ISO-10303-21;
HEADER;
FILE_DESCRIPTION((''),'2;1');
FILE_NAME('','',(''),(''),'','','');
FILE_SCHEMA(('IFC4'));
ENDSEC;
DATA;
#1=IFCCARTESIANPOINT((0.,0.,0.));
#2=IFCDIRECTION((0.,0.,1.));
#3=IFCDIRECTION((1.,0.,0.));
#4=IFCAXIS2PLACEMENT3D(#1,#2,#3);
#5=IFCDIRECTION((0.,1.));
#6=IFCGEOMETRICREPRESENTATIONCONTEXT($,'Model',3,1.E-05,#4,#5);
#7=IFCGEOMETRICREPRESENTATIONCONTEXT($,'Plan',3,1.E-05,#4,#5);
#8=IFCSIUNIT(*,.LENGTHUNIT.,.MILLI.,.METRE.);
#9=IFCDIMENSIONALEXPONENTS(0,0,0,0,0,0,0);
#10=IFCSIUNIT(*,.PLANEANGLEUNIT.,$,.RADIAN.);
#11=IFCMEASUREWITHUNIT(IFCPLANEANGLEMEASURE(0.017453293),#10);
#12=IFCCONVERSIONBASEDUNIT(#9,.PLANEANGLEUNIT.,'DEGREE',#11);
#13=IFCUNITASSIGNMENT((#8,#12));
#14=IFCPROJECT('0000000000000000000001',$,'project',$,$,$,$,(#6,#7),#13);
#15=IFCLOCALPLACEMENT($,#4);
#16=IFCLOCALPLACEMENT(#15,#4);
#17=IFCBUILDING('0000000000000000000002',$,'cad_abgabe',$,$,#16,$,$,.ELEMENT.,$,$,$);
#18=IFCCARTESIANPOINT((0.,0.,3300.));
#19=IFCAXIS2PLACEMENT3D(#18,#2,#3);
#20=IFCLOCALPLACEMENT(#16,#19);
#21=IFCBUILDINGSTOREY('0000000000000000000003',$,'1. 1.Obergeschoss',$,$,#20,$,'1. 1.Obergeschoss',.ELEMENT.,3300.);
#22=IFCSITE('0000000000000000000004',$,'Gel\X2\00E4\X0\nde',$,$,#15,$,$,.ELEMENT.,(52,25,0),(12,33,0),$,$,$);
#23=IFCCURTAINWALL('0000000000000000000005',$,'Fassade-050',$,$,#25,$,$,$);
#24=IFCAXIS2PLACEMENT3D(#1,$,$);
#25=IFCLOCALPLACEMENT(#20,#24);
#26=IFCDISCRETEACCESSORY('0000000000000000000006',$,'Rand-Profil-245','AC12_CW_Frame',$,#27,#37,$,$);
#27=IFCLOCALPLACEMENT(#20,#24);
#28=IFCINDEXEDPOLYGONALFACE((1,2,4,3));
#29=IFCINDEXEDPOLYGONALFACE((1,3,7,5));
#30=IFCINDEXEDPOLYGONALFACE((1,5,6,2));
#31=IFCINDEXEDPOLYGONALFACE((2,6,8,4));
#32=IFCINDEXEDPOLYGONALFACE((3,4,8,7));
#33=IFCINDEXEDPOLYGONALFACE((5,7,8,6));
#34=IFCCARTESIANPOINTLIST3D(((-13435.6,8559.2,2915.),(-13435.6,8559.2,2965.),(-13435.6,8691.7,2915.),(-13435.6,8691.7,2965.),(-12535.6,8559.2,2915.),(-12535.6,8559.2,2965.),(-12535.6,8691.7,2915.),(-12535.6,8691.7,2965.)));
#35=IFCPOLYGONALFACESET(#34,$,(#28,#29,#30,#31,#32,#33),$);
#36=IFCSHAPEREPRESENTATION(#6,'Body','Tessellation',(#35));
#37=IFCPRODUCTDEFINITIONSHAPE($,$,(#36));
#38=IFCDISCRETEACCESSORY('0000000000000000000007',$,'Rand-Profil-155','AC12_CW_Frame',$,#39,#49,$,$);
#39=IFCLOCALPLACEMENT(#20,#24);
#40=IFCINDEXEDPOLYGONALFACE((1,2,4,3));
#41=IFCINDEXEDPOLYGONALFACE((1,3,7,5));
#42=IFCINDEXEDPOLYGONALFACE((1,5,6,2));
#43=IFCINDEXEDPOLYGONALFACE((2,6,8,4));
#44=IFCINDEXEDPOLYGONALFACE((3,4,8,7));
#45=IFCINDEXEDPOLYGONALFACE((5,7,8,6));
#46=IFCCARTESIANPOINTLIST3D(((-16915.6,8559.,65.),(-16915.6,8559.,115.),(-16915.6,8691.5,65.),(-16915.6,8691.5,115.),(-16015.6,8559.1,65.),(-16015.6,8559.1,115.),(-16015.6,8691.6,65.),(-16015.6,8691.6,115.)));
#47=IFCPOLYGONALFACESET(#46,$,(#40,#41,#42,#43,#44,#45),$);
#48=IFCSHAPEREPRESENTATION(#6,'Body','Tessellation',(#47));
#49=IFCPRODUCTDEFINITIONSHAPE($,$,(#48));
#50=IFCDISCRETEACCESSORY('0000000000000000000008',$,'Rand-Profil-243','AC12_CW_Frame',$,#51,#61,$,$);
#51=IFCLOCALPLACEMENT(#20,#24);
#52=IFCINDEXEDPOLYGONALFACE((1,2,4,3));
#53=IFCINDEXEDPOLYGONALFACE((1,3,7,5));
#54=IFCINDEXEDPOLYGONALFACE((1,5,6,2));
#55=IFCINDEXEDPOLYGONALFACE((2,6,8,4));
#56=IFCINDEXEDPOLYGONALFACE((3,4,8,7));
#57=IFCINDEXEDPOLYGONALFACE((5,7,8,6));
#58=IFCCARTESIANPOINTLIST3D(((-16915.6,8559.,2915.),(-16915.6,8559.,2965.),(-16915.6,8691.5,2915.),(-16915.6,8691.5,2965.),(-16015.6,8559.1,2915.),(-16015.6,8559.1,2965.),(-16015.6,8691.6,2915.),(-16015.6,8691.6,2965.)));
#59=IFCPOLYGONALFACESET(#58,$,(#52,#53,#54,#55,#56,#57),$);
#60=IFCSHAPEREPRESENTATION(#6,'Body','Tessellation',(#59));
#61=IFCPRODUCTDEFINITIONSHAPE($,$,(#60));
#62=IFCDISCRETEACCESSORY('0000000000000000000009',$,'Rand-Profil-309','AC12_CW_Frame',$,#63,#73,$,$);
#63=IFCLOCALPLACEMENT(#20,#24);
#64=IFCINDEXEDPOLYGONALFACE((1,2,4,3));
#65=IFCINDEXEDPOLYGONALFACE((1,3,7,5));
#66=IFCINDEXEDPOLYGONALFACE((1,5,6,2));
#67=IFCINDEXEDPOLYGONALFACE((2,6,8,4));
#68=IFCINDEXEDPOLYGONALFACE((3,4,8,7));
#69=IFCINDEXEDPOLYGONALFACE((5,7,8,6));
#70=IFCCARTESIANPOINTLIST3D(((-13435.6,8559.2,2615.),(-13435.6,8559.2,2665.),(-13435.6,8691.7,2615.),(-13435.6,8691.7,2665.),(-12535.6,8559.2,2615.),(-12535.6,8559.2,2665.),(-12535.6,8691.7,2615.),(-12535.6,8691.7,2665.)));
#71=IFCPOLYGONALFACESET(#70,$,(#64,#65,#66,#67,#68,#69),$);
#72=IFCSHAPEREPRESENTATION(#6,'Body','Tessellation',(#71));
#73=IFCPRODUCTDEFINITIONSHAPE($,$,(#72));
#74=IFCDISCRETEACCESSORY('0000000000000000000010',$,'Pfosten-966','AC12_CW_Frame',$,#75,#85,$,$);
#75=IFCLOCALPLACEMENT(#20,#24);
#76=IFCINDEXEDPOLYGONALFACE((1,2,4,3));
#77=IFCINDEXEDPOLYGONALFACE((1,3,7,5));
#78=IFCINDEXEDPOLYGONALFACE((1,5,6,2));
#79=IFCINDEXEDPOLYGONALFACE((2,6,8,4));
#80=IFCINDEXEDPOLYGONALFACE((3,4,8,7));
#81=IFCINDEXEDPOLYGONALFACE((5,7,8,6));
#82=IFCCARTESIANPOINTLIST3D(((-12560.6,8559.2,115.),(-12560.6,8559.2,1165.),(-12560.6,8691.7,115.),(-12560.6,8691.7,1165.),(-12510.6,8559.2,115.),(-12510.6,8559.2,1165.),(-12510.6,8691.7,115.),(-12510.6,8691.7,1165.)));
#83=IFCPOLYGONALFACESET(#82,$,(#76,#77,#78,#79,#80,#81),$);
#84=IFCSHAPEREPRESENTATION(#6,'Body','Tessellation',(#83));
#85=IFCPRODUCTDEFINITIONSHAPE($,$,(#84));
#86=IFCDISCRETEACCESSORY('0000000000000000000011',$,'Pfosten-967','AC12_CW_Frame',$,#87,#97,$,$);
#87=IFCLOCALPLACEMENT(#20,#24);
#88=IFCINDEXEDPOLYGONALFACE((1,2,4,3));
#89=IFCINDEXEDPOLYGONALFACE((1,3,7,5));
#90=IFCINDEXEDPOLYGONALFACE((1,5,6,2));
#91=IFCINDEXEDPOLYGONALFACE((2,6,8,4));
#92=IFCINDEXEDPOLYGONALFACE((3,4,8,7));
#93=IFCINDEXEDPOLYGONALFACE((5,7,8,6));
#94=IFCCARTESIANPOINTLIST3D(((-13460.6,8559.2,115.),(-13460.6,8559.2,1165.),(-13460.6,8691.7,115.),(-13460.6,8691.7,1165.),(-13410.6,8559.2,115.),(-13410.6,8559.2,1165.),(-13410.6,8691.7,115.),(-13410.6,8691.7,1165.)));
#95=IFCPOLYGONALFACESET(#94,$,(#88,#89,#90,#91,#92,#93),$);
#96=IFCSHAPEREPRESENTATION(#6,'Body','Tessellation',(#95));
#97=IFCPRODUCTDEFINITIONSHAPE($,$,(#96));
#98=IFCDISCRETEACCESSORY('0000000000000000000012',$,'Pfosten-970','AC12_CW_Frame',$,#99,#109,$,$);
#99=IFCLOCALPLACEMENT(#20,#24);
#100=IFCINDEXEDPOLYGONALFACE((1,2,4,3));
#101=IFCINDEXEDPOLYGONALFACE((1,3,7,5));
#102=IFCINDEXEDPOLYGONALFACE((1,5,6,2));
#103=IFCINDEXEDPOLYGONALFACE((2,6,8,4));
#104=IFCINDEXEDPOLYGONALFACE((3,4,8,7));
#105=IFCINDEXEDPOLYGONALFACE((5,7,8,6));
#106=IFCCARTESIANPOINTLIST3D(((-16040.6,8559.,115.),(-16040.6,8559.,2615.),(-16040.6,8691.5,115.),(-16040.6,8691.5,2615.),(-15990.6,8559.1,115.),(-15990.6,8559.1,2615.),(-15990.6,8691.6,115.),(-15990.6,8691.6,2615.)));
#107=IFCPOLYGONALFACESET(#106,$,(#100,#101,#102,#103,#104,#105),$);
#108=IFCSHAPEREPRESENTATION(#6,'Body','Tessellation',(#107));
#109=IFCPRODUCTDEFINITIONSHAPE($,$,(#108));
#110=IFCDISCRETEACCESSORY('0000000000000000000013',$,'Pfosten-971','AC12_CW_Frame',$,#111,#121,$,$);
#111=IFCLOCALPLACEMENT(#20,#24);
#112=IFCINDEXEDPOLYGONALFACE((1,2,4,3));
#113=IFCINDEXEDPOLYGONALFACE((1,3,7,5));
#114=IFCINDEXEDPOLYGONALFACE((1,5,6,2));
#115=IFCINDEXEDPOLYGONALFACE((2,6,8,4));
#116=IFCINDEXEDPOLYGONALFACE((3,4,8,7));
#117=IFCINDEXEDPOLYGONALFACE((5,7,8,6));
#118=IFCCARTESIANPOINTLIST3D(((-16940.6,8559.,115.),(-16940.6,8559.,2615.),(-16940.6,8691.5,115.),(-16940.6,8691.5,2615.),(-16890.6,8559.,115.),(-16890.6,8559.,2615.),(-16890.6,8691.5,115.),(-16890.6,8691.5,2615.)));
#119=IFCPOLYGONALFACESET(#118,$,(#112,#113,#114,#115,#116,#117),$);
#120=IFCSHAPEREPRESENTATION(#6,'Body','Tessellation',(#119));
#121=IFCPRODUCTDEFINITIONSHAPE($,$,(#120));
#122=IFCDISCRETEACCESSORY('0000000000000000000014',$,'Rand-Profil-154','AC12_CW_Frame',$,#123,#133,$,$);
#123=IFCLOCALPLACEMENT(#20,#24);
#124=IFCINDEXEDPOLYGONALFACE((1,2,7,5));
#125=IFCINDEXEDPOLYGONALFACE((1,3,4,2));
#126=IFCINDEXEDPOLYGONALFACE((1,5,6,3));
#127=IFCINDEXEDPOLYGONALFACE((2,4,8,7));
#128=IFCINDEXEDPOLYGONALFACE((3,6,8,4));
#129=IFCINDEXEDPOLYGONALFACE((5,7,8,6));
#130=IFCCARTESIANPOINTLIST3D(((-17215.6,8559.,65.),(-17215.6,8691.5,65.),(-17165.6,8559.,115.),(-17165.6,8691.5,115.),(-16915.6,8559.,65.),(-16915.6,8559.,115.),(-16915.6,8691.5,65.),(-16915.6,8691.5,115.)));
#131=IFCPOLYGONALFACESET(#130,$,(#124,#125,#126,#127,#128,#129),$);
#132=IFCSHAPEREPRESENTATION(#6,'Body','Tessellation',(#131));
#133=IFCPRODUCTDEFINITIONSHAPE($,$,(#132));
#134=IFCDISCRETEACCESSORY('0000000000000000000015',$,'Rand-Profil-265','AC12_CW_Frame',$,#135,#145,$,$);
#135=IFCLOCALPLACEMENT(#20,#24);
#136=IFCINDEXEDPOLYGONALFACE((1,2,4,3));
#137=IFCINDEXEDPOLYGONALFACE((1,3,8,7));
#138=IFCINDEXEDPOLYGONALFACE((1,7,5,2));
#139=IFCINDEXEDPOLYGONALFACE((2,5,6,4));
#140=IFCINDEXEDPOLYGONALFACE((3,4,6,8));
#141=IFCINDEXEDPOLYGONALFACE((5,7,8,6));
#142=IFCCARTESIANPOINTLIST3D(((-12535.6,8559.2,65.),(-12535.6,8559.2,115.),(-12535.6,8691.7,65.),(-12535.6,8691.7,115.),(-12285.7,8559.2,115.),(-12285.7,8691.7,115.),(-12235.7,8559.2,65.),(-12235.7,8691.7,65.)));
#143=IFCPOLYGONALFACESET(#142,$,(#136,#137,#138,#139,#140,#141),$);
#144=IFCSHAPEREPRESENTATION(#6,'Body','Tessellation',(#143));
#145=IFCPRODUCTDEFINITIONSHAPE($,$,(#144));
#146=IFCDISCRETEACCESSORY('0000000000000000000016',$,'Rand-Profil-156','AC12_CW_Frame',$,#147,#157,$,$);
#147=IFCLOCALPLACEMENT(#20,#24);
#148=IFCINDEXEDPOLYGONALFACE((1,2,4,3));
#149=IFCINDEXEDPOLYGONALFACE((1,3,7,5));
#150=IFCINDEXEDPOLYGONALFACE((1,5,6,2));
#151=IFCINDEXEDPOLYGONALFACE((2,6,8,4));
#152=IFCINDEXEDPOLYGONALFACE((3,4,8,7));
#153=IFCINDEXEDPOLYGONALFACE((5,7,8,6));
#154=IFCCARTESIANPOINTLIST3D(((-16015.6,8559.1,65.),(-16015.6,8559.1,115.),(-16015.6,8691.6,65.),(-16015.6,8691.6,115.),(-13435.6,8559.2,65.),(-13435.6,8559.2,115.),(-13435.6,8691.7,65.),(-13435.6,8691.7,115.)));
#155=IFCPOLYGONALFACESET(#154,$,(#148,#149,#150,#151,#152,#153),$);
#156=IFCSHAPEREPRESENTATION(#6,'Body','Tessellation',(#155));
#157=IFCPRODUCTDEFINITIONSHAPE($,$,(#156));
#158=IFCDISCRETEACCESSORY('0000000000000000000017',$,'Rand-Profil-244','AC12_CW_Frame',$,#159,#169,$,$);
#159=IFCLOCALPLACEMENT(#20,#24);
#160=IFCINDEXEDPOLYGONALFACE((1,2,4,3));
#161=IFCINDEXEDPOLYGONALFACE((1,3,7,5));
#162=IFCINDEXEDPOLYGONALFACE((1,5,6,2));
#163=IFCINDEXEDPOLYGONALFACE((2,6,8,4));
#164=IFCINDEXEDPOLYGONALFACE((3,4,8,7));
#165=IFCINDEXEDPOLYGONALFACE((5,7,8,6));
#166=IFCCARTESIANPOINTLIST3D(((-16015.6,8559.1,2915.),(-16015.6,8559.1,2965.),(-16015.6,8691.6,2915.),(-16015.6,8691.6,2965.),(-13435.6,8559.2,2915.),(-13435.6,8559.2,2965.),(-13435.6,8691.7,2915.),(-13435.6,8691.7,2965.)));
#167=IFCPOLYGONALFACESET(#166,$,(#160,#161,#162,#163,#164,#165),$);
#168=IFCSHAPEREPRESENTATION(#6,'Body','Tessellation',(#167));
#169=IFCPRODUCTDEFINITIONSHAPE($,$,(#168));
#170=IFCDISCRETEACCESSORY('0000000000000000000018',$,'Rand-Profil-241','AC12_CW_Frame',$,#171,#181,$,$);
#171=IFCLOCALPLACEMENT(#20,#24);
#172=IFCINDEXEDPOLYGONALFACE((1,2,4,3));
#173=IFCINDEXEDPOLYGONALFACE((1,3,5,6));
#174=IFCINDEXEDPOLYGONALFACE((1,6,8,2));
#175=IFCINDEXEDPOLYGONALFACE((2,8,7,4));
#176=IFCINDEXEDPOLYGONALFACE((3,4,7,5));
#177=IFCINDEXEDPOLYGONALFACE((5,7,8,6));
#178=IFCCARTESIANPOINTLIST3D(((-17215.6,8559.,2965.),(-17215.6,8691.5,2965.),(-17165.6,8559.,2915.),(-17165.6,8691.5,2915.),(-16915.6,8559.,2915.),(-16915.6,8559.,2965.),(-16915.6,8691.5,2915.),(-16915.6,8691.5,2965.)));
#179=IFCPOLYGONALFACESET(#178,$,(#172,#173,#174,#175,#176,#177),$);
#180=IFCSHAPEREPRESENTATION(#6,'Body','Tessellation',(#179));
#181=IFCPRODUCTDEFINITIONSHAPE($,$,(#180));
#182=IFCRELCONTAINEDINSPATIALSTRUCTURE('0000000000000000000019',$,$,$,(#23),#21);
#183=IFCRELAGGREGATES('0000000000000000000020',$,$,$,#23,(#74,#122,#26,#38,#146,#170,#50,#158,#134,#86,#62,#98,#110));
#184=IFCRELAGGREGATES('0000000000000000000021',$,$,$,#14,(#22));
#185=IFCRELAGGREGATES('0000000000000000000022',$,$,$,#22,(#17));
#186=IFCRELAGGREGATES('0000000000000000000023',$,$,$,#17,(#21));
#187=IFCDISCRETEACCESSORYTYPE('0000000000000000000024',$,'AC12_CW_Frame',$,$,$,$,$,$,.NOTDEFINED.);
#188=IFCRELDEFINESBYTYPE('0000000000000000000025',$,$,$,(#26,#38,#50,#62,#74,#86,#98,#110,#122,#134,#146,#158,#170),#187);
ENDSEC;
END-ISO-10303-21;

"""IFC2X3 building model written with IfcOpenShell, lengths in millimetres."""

from ifc_helpers import new_model, entity, si_unit, converted_unit, direction, frame, origin_with_axes, place, context, project, spatial, polyline, outline, extrude, source, transform, mapped, type_object, element, aggregate, save


model = new_model("IFC2X3")

# Units and contexts
model_context = context("Model", 3, precision=1e-05, world=origin_with_axes(), true_north=direction((0.0, 1.0)))
plan_context = context("Plan", 3, precision=1e-05, world=origin_with_axes(), true_north=direction((0.0, 1.0)))
ifc_project = project(units=[si_unit("LENGTHUNIT", "METRE", prefix="MILLI"), converted_unit("PLANEANGLEUNIT", "DEGREE", entity("IfcPlaneAngleMeasure", 0.017453293), si_unit("PLANEANGLEUNIT", "RADIAN"), dimensions=[0, 0, 0, 0, 0, 0, 0])], contexts=[model_context, plan_context])

# Site, building, storey
site_placement = place(None, origin_with_axes())
site = spatial("IfcSite", under=ifc_project, at=site_placement, Name="Gelände", CompositionType="ELEMENT", RefLatitude=(52, 25, 0), RefLongitude=(12, 33, 0))
building_placement = place(site_placement, origin_with_axes())
building = spatial("IfcBuilding", under=site, at=building_placement, Name="cad_abgabe", CompositionType="ELEMENT")
storey_placement = place(building_placement, frame((0.0, 0.0, 3300.0), z_axis=(0.0, 0.0, 1.0), x_axis=(1.0, 0.0, 0.0)))
storey = spatial("IfcBuildingStorey", under=building, at=storey_placement, Name="1. 1.Obergeschoss", LongName="1. 1.Obergeschoss", CompositionType="ELEMENT", Elevation=3300.0)

# Curtain wall
curtain_wall_placement = place(storey_placement, frame((-17190.6, 8614.0, 90.0), z_axis=(0.0, 0.0, 1.0), x_axis=(1.0, 0.000045, 0.0)))
curtain_wall = element("IfcCurtainWall", 1, at=curtain_wall_placement, inside=storey, Name="Fassade-050")

# Discrete accessories
discrete_accessory_type = type_object("IfcDiscreteAccessoryType", Name="AC12_CW_Frame")
shared_shape_1 = source(origin_with_axes(), model_context, "Body", "SweptSolid", [
    extrude(outline(polyline([(0.0, 0.0), (132.5, 0.0), (132.5, -900.0), (0.0, -900.0), (0.0, 0.0)])), origin_with_axes(), (0.0, 0.0, 1.0), 50.0),
])
discrete_accessory_1_placement = place(storey_placement, frame((-12535.6, 8691.7, 2915.0), z_axis=(0.0, 0.0, 1.0), x_axis=(0.000045, -1.0, 0.0)))
discrete_accessory_1 = element("IfcDiscreteAccessory", 2, at=discrete_accessory_1_placement, type_object=discrete_accessory_type, Name="Rand-Profil-245", Description="AC12_CW_Frame", context=model_context, shape_type="MappedRepresentation", body=[
    mapped(shared_shape_1, transform((0.0, 0.0, 0.0), scale=1.0)),
])
discrete_accessory_2_placement = place(storey_placement, frame((-16915.6, 8691.5, 115.0), z_axis=(0.0, 0.0, -1.0), x_axis=(0.000045, -1.0, 0.0)))
discrete_accessory_2 = element("IfcDiscreteAccessory", 3, at=discrete_accessory_2_placement, type_object=discrete_accessory_type, Name="Rand-Profil-155", Description="AC12_CW_Frame", context=model_context, shape_type="MappedRepresentation", body=[
    mapped(shared_shape_1, transform((0.0, 0.0, 0.0), scale=1.0)),
])
discrete_accessory_3_placement = place(storey_placement, frame((-16015.6, 8691.6, 2915.0), z_axis=(0.0, 0.0, 1.0), x_axis=(0.000045, -1.0, 0.0)))
discrete_accessory_3 = element("IfcDiscreteAccessory", 4, at=discrete_accessory_3_placement, type_object=discrete_accessory_type, Name="Rand-Profil-243", Description="AC12_CW_Frame", context=model_context, shape_type="MappedRepresentation", body=[
    mapped(shared_shape_1, transform((0.0, 0.0, 0.0), scale=1.0)),
])
discrete_accessory_4_placement = place(storey_placement, frame((-12535.6, 8691.7, 2615.0), z_axis=(0.0, 0.0, 1.0), x_axis=(0.000045, -1.0, 0.0)))
discrete_accessory_4 = element("IfcDiscreteAccessory", 5, at=discrete_accessory_4_placement, type_object=discrete_accessory_type, Name="Rand-Profil-309", Description="AC12_CW_Frame", context=model_context, shape_type="MappedRepresentation", body=[
    mapped(shared_shape_1, transform((0.0, 0.0, 0.0), scale=1.0)),
])
shared_shape_2 = source(origin_with_axes(), model_context, "Body", "SweptSolid", [
    extrude(outline(polyline([(0.0, 0.0), (132.5, 0.0), (132.5, -1050.0), (0.0, -1050.0), (0.0, 0.0)])), origin_with_axes(), (0.0, 0.0, 1.0), 50.0),
])
discrete_accessory_5_placement = place(storey_placement, frame((-12560.6, 8691.7, 115.0), z_axis=(1.0, 0.000045, 0.0), x_axis=(0.000045, -1.0, 0.0)))
discrete_accessory_5 = element("IfcDiscreteAccessory", 6, at=discrete_accessory_5_placement, type_object=discrete_accessory_type, Name="Pfosten-966", Description="AC12_CW_Frame", context=model_context, shape_type="MappedRepresentation", body=[
    mapped(shared_shape_2, transform((0.0, 0.0, 0.0), scale=1.0)),
])
discrete_accessory_6_placement = place(storey_placement, frame((-13460.6, 8691.7, 115.0), z_axis=(1.0, 0.000045, 0.0), x_axis=(0.000045, -1.0, 0.0)))
discrete_accessory_6 = element("IfcDiscreteAccessory", 7, at=discrete_accessory_6_placement, type_object=discrete_accessory_type, Name="Pfosten-967", Description="AC12_CW_Frame", context=model_context, shape_type="MappedRepresentation", body=[
    mapped(shared_shape_2, transform((0.0, 0.0, 0.0), scale=1.0)),
])
shared_shape_3 = source(origin_with_axes(), model_context, "Body", "SweptSolid", [
    extrude(outline(polyline([(0.0, 0.0), (132.5, 0.0), (132.5, -2500.0), (0.0, -2500.0), (0.0, 0.0)])), origin_with_axes(), (0.0, 0.0, 1.0), 50.0),
])
discrete_accessory_7_placement = place(storey_placement, frame((-16040.6, 8691.5, 115.0), z_axis=(1.0, 0.000045, 0.0), x_axis=(0.000045, -1.0, 0.0)))
discrete_accessory_7 = element("IfcDiscreteAccessory", 8, at=discrete_accessory_7_placement, type_object=discrete_accessory_type, Name="Pfosten-970", Description="AC12_CW_Frame", context=model_context, shape_type="MappedRepresentation", body=[
    mapped(shared_shape_3, transform((0.0, 0.0, 0.0), scale=1.0)),
])
discrete_accessory_8_placement = place(storey_placement, frame((-16940.6, 8691.5, 115.0), z_axis=(1.0, 0.000045, 0.0), x_axis=(0.000045, -1.0, 0.0)))
discrete_accessory_8 = element("IfcDiscreteAccessory", 9, at=discrete_accessory_8_placement, type_object=discrete_accessory_type, Name="Pfosten-971", Description="AC12_CW_Frame", context=model_context, shape_type="MappedRepresentation", body=[
    mapped(shared_shape_3, transform((0.0, 0.0, 0.0), scale=1.0)),
])
shared_shape_4 = source(origin_with_axes(), model_context, "Body", "SweptSolid", [
    extrude(outline(polyline([(0.0, 0.0), (70.7, 0.0), (-141.4, -212.1), (-176.8, -176.8), (0.0, 0.0)])), origin_with_axes(), (0.0, 0.0, 1.0), 132.5),
])
discrete_accessory_9_placement = place(storey_placement, frame((-17165.6, 8559.0, 115.0), z_axis=(-0.000045, 1.0, 0.0), x_axis=(-0.707107, -0.000032, -0.707107)))
discrete_accessory_9 = element("IfcDiscreteAccessory", 10, at=discrete_accessory_9_placement, type_object=discrete_accessory_type, Name="Rand-Profil-154", Description="AC12_CW_Frame", context=model_context, shape_type="MappedRepresentation", body=[
    mapped(shared_shape_4, transform((0.0, 0.0, 0.0), scale=1.0)),
])
shared_shape_5 = source(origin_with_axes(), model_context, "Body", "SweptSolid", [
    extrude(outline(polyline([(0.0, 0.0), (50.0, 0.0), (50.0, -299.8), (0.0, -249.8), (0.0, 0.0)])), origin_with_axes(), (0.0, 0.0, 1.0), 132.5),
])
discrete_accessory_10_placement = place(storey_placement, frame((-12535.6, 8559.2, 115.0), z_axis=(-0.000045, 1.0, 0.0), x_axis=(0.0, 0.0, -1.0)))
discrete_accessory_10 = element("IfcDiscreteAccessory", 11, at=discrete_accessory_10_placement, type_object=discrete_accessory_type, Name="Rand-Profil-265", Description="AC12_CW_Frame", context=model_context, shape_type="MappedRepresentation", body=[
    mapped(shared_shape_5, transform((0.0, 0.0, 0.0), scale=1.0)),
])
shared_shape_6 = source(origin_with_axes(), model_context, "Body", "SweptSolid", [
    extrude(outline(polyline([(0.0, 0.0), (132.5, 0.0), (132.5, -2580.0), (0.0, -2580.0), (0.0, 0.0)])), origin_with_axes(), (0.0, 0.0, 1.0), 50.0),
])
discrete_accessory_11_placement = place(storey_placement, frame((-16015.6, 8691.6, 115.0), z_axis=(0.0, 0.0, -1.0), x_axis=(0.000045, -1.0, 0.0)))
discrete_accessory_11 = element("IfcDiscreteAccessory", 12, at=discrete_accessory_11_placement, type_object=discrete_accessory_type, Name="Rand-Profil-156", Description="AC12_CW_Frame", context=model_context, shape_type="MappedRepresentation", body=[
    mapped(shared_shape_6, transform((0.0, 0.0, 0.0), scale=1.0)),
])
discrete_accessory_12_placement = place(storey_placement, frame((-13435.6, 8691.7, 2915.0), z_axis=(0.0, 0.0, 1.0), x_axis=(0.000045, -1.0, 0.0)))
discrete_accessory_12 = element("IfcDiscreteAccessory", 13, at=discrete_accessory_12_placement, type_object=discrete_accessory_type, Name="Rand-Profil-244", Description="AC12_CW_Frame", context=model_context, shape_type="MappedRepresentation", body=[
    mapped(shared_shape_6, transform((0.0, 0.0, 0.0), scale=1.0)),
])
shared_shape_7 = source(origin_with_axes(), model_context, "Body", "SweptSolid", [
    extrude(outline(polyline([(0.0, 0.0), (50.0, 0.0), (50.0, -300.0), (0.0, -250.0), (0.0, 0.0)])), origin_with_axes(), (0.0, 0.0, 1.0), 132.5),
])
discrete_accessory_13_placement = place(storey_placement, frame((-16915.6, 8559.0, 2915.0), z_axis=(-0.000045, 1.0, 0.0), x_axis=(0.0, 0.0, 1.0)))
discrete_accessory_13 = element("IfcDiscreteAccessory", 14, at=discrete_accessory_13_placement, type_object=discrete_accessory_type, Name="Rand-Profil-241", Description="AC12_CW_Frame", context=model_context, shape_type="MappedRepresentation", body=[
    mapped(shared_shape_7, transform((0.0, 0.0, 0.0), scale=1.0)),
])
aggregate(curtain_wall, [discrete_accessory_5, discrete_accessory_9, discrete_accessory_1, discrete_accessory_2, discrete_accessory_11, discrete_accessory_13, discrete_accessory_3, discrete_accessory_12, discrete_accessory_10, discrete_accessory_6, discrete_accessory_4, discrete_accessory_7, discrete_accessory_8])

save(model, "model.ifc")
